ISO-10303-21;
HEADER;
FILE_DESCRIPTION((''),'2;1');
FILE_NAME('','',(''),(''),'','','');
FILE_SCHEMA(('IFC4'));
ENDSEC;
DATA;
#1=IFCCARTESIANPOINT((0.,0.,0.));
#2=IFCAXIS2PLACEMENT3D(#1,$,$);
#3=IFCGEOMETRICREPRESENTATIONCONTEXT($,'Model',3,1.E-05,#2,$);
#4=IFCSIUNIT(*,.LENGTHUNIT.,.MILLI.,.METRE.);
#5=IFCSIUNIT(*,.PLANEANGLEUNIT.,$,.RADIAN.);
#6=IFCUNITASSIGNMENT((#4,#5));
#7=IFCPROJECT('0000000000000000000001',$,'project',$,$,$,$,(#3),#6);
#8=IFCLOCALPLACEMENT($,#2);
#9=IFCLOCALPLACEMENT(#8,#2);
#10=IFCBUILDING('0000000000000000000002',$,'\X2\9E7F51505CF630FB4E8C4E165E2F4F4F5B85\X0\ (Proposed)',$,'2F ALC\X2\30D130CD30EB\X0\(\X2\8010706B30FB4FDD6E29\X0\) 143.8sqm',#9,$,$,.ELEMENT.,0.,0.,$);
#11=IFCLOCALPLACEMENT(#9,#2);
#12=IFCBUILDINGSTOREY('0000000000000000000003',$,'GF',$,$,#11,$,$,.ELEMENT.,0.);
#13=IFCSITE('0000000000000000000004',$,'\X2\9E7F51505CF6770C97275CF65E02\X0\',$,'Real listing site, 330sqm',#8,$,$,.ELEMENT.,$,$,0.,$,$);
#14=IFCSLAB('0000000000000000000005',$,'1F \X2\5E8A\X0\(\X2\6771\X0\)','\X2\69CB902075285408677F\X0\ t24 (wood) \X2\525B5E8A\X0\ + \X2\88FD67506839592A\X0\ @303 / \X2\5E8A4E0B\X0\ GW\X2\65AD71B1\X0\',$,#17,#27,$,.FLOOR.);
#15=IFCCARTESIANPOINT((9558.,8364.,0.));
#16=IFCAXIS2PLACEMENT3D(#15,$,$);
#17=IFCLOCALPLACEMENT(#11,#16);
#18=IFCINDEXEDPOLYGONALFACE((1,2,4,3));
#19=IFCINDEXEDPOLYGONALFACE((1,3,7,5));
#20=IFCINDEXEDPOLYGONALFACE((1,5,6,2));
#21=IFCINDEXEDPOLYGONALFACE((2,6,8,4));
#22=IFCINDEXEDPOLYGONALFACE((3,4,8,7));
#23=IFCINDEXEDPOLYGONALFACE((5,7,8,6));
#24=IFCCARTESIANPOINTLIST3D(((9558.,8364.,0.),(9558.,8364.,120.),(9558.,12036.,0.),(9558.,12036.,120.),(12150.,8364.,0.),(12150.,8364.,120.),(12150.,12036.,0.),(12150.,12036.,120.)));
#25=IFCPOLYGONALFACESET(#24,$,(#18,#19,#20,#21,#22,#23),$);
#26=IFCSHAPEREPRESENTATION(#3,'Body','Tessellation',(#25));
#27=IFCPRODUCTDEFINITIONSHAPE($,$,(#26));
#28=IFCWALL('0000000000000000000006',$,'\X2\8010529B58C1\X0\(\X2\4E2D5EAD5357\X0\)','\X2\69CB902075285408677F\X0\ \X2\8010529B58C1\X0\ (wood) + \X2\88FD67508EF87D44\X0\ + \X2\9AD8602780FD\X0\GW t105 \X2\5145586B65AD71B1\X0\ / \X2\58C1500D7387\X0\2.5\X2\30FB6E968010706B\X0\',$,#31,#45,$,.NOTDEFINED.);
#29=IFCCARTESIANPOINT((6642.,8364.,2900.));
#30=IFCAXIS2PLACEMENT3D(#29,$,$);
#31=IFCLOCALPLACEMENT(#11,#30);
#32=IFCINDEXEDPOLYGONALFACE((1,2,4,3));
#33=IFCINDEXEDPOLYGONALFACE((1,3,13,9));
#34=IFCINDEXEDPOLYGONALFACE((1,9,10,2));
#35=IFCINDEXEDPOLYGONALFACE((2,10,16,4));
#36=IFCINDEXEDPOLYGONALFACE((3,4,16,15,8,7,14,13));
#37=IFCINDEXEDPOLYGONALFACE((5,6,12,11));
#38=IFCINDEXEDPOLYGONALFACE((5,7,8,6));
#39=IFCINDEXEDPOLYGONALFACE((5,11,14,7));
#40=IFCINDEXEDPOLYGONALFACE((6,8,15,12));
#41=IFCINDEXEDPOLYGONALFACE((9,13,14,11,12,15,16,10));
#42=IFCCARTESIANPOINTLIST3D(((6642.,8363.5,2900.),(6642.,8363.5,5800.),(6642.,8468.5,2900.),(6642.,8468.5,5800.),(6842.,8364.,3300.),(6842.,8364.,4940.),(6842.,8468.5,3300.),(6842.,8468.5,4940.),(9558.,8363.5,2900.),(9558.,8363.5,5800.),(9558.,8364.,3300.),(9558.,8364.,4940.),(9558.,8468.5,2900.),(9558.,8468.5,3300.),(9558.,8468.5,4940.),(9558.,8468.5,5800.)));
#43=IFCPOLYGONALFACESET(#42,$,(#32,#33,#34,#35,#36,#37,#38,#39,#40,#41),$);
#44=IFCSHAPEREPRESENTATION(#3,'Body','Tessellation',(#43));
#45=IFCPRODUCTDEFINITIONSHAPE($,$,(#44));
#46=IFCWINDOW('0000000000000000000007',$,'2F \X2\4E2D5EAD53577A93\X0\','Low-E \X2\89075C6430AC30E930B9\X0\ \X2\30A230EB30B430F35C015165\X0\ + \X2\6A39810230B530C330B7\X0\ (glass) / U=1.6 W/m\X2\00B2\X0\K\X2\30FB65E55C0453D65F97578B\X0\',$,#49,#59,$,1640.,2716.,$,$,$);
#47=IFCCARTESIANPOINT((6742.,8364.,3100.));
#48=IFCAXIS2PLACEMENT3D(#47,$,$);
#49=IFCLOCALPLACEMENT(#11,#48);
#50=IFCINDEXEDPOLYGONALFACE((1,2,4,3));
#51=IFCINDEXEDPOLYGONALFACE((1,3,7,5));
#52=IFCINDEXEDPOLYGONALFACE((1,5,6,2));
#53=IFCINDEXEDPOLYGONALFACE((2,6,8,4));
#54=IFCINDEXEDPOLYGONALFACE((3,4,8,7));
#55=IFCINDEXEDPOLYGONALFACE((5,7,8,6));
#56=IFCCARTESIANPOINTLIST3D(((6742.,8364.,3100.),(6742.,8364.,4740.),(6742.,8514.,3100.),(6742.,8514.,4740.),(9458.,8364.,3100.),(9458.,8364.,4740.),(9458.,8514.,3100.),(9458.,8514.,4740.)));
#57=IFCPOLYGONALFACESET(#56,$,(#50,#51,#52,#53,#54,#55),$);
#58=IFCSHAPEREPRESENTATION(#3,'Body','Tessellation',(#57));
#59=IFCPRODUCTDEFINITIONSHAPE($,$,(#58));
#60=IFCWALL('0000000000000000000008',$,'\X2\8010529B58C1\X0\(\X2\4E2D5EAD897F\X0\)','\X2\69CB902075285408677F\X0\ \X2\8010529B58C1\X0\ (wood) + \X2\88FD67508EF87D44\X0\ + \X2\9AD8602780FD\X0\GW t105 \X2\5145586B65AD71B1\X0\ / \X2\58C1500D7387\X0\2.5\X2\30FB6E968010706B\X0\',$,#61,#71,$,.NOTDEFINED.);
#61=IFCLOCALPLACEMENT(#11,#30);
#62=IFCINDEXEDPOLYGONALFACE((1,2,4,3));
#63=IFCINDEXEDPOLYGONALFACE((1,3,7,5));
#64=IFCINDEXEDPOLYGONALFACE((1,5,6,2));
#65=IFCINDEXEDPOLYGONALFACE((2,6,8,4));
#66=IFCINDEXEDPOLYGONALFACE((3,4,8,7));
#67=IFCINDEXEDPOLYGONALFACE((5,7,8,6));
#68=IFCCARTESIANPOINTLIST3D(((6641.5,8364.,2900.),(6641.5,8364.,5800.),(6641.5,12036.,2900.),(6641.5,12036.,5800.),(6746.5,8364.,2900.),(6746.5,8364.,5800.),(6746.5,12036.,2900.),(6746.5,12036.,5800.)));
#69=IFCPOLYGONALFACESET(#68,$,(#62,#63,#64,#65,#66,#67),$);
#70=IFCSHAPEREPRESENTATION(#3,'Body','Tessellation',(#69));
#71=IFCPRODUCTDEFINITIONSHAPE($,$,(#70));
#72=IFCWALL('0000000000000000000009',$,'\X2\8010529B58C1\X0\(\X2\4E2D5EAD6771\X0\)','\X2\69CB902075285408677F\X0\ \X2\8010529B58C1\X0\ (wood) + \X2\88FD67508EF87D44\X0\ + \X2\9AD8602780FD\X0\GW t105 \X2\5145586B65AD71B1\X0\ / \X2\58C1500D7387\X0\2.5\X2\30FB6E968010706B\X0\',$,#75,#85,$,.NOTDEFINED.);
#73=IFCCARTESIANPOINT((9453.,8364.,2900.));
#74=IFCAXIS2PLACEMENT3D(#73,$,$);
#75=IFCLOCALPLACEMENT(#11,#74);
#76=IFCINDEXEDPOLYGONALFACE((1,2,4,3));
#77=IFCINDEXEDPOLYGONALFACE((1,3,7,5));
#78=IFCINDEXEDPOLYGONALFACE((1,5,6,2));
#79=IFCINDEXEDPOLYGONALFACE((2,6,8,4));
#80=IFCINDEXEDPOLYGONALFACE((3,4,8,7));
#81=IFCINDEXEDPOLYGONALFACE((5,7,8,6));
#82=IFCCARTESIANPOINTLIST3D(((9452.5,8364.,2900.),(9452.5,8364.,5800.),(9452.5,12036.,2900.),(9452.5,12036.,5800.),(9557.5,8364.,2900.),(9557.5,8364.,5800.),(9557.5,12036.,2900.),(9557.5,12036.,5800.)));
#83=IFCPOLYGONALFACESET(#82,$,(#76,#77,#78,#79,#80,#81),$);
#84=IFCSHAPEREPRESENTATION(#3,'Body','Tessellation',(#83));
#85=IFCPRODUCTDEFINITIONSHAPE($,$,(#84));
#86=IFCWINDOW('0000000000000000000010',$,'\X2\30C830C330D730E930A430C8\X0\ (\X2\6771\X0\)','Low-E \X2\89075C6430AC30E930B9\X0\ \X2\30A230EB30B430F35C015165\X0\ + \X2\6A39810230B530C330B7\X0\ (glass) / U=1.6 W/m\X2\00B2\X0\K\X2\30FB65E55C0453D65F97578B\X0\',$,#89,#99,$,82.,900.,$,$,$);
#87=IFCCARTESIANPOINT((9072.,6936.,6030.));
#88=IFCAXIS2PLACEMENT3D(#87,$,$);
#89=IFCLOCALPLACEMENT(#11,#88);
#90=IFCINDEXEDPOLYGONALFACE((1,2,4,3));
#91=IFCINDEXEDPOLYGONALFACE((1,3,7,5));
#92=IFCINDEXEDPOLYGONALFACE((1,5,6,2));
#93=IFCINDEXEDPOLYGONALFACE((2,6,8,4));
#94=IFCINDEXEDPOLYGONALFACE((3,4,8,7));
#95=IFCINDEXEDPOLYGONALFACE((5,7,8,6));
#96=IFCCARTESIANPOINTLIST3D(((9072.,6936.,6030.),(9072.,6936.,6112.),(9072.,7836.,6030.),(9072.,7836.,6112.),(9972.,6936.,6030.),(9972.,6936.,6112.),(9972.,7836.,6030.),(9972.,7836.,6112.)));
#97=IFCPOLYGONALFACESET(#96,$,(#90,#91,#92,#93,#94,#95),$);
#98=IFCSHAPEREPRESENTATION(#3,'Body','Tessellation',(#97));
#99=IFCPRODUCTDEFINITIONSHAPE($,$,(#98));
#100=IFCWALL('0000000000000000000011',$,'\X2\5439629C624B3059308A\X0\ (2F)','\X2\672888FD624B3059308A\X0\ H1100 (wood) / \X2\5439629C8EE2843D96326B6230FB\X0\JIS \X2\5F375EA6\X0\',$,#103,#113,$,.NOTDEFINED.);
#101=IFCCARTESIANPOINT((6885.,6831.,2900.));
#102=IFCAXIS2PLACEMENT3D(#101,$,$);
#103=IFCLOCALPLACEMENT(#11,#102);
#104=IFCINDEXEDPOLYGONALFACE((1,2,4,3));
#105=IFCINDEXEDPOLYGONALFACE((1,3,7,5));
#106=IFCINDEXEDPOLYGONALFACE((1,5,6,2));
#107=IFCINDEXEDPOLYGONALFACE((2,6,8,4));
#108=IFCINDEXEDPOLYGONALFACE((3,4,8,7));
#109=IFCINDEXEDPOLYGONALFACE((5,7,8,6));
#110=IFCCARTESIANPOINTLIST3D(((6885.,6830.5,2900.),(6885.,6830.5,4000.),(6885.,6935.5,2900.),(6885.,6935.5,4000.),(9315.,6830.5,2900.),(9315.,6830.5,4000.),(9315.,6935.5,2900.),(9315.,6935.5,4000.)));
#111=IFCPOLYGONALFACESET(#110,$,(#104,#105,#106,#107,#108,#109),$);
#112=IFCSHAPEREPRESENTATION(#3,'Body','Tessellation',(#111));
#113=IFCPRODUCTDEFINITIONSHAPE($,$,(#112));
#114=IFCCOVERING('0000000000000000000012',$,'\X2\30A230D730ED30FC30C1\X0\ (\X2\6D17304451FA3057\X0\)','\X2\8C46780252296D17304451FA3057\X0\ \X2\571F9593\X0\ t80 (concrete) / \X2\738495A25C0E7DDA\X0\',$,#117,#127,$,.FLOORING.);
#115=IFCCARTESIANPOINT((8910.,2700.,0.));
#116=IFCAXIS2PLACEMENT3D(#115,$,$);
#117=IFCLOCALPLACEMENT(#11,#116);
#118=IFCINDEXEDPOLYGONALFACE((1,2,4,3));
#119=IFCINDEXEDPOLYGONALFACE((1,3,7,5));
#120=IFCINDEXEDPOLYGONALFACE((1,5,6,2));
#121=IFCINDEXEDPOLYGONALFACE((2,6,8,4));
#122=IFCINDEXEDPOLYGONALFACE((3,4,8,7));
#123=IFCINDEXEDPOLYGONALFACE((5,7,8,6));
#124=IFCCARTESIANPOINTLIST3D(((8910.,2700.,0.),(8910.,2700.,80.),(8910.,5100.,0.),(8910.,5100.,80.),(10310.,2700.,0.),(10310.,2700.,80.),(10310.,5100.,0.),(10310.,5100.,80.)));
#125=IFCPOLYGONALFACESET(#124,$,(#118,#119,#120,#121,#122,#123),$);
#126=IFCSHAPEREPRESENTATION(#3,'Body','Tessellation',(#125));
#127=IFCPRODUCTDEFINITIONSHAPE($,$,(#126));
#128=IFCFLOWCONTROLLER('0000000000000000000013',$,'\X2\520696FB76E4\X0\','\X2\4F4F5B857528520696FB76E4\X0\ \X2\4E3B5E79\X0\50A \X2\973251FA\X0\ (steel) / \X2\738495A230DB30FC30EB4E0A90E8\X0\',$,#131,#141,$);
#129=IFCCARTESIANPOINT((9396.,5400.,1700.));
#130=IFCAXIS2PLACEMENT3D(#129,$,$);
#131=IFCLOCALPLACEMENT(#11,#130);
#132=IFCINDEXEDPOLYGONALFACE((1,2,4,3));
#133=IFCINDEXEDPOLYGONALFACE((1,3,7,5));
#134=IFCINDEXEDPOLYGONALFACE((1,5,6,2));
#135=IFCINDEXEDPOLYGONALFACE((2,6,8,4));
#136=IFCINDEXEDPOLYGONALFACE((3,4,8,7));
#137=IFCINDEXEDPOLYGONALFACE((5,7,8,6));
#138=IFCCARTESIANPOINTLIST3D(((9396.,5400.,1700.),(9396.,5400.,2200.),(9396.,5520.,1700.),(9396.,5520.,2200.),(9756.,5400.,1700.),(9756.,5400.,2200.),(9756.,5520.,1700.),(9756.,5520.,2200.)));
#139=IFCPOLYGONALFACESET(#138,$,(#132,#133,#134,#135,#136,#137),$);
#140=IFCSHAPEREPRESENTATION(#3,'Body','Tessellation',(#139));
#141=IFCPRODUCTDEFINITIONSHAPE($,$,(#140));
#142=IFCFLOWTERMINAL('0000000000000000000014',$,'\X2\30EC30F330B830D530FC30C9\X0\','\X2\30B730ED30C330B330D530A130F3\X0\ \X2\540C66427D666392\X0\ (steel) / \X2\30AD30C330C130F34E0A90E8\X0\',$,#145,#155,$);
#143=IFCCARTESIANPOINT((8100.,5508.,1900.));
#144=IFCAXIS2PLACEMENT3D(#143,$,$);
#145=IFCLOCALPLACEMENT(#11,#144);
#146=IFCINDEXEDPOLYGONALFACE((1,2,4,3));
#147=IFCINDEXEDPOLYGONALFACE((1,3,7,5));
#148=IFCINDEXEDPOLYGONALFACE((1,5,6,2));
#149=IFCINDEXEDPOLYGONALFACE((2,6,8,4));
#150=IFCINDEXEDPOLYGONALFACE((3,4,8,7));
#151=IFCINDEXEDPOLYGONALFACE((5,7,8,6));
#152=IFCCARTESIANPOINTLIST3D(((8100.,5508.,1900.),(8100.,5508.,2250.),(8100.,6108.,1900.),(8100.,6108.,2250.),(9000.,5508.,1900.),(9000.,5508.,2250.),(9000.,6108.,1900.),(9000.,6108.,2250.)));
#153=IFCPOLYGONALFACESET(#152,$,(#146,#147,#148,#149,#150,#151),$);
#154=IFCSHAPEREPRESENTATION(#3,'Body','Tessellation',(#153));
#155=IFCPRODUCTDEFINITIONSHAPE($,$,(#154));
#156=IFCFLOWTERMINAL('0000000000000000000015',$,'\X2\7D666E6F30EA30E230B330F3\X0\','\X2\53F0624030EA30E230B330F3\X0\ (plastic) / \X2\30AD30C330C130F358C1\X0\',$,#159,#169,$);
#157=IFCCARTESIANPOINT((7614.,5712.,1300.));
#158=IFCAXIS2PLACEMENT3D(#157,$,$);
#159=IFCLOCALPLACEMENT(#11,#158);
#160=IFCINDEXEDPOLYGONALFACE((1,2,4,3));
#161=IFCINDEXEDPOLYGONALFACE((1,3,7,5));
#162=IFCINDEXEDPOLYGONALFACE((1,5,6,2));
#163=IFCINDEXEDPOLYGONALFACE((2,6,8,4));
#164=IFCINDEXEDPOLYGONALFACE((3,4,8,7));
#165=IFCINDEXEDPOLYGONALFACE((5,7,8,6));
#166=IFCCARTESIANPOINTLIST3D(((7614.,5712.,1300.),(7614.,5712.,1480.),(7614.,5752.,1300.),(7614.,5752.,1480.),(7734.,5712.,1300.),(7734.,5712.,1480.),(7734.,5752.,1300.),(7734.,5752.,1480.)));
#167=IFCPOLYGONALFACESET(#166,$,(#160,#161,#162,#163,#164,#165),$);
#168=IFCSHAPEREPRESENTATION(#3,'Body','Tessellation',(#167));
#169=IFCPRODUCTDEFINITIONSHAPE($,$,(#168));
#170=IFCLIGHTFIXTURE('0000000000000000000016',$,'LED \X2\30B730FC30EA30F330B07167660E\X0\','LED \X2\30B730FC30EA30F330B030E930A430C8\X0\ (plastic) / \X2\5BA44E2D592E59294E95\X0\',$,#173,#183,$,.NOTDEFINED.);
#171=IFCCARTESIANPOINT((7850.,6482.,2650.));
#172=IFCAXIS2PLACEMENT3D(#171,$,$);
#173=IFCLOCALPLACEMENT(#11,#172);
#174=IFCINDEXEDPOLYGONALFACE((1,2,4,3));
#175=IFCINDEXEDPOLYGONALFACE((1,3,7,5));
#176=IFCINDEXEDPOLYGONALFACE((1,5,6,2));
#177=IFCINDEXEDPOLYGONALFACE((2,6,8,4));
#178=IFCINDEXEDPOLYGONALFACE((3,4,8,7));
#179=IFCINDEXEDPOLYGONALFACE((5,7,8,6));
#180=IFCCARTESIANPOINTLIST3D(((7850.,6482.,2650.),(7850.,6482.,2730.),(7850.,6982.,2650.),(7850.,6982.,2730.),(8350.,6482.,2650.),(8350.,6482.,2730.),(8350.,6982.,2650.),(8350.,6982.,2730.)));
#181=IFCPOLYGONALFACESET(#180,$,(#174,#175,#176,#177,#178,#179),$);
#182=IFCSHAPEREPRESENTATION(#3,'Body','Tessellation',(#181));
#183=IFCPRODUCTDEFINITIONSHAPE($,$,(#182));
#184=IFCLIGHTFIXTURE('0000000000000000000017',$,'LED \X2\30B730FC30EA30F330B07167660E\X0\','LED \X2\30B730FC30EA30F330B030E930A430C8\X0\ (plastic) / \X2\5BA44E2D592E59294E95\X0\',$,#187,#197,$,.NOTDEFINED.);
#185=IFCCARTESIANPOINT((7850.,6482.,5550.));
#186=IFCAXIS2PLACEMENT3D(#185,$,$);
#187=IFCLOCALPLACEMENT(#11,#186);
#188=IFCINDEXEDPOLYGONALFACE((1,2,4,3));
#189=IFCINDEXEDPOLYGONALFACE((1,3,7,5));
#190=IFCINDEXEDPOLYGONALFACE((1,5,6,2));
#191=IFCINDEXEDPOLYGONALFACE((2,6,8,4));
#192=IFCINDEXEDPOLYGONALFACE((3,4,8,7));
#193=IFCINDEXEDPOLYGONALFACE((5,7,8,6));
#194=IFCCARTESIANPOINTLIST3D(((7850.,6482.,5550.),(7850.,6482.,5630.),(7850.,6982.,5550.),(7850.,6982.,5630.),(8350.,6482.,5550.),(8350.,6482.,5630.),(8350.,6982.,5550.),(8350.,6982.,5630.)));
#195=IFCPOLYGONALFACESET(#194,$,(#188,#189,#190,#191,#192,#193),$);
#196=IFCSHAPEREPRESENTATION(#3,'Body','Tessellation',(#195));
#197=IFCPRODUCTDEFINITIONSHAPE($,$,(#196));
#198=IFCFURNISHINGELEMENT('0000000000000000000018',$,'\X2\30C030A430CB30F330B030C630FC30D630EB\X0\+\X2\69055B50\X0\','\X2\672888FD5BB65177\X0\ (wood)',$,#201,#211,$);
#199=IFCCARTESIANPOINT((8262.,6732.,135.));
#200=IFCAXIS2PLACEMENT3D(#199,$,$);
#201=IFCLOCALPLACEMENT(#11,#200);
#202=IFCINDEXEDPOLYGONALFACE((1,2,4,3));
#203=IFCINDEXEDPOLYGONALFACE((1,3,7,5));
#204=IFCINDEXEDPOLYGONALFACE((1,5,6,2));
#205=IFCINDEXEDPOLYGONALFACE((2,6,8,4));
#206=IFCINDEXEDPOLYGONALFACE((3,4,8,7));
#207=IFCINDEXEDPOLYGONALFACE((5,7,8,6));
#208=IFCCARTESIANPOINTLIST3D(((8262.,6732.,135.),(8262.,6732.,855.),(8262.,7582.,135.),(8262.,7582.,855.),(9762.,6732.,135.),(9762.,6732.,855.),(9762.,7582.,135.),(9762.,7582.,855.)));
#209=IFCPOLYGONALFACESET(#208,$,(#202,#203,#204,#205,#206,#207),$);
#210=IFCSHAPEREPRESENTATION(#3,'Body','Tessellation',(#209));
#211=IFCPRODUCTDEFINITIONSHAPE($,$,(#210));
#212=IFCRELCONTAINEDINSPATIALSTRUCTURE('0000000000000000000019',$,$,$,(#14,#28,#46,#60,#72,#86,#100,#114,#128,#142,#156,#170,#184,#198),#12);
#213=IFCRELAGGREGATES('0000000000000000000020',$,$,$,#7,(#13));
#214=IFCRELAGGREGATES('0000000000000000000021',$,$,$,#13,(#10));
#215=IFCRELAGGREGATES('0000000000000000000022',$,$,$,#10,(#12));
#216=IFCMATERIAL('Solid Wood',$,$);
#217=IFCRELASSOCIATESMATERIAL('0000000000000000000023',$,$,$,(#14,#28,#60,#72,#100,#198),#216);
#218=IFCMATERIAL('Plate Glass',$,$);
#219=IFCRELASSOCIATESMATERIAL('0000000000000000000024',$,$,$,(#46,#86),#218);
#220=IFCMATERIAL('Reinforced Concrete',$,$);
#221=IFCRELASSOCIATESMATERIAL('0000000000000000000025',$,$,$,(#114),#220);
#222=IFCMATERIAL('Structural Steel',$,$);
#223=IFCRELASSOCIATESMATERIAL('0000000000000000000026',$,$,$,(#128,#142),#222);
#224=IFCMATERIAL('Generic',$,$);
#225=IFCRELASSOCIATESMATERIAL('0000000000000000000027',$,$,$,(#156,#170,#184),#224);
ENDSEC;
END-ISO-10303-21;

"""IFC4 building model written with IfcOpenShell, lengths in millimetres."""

from ifc_helpers import new_model, si_unit, frame, frame_2d, origin, place, context, project, spatial, rectangle, extrude, material, element, fill, save


model = new_model("IFC4")

# Units and contexts
model_context = context("Model", 3, precision=1e-05, world=origin())
ifc_project = project(units=[si_unit("LENGTHUNIT", "METRE", prefix="MILLI"), si_unit("PLANEANGLEUNIT", "RADIAN")], contexts=[model_context])

# Site, building, storey
site_placement = place(None, origin())
site = spatial("IfcSite", under=ifc_project, at=site_placement, Name="鹿児島県霧島市", ObjectType="Real listing site, 330sqm", CompositionType="ELEMENT", RefElevation=0.0)
building_placement = place(site_placement, origin())
building = spatial("IfcBuilding", under=site, at=building_placement, Name="鹿児島・二世帯住宅 (Proposed)", ObjectType="2F ALCパネル(耐火・保温) 143.8sqm", CompositionType="ELEMENT", ElevationOfRefHeight=0.0, ElevationOfTerrain=0.0)
storey_placement = place(building_placement, origin())
storey = spatial("IfcBuildingStorey", under=building, at=storey_placement, Name="GF", CompositionType="ELEMENT", Elevation=0.0)

# Shared definitions
ifc_material_1 = material(Name="Solid Wood")

# Slab
slab_placement = place(storey_placement, frame((9558.0, 8364.0, 0.0)))
element("IfcSlab", 1, at=slab_placement, inside=storey, material=ifc_material_1, Name="1F 床(東)", Description="構造用合板 t24 (wood) 剛床 + 製材根太 @303 / 床下 GW断熱", PredefinedType="FLOOR", context=model_context, shape_type="SweptSolid", body=[
    extrude(rectangle(XDim=2592.0, YDim=3672.0, at=frame_2d((1296.0, 1836.0))), frame((9558.0, 8364.0, 0.0)), (0.0, 0.0, 1.0), 120.0),
])

# Wall, opening, window
wall_1_placement = place(storey_placement, frame((6642.0, 8364.0, 2900.0)))
wall_1 = element("IfcWall", 2, at=wall_1_placement, inside=storey, material=ifc_material_1, Name="耐力壁(中庭南)", Description="構造用合板 耐力壁 (wood) + 製材軸組 + 高性能GW t105 充填断熱 / 壁倍率2.5・準耐火", PredefinedType="NOTDEFINED", context=model_context, shape_type="SweptSolid", body=[
    extrude(rectangle(XDim=2916.0, YDim=105.0, at=frame_2d((1458.0, 52.0))), frame((6642.0, 8364.0, 2900.0)), (0.0, 0.0, 1.0), 2900.0),
])
opening_placement = place(storey_placement, frame((6742.0, 8364.0, 3100.0)))
opening = element("IfcOpeningElement", 3, at=opening_placement, cuts=wall_1, PredefinedType="NOTDEFINED", context=model_context, shape_type="SweptSolid", body=[
    extrude(rectangle(XDim=2716.0, YDim=150.0, at=frame_2d((1358.0, 75.0))), frame((6742.0, 8364.0, 3100.0)), (0.0, 0.0, 1.0), 1640.0),
])
ifc_material_2 = material(Name="Plate Glass")
window_1_placement = place(storey_placement, frame((6742.0, 8364.0, 3100.0)))
window_1 = element("IfcWindow", 4, at=window_1_placement, inside=storey, material=ifc_material_2, Name="2F 中庭南窓", Description="Low-E 複層ガラス アルゴン封入 + 樹脂サッシ (glass) / U=1.6 W/m²K・日射取得型", OverallHeight=1640.0, OverallWidth=2716.0, context=model_context, shape_type="SweptSolid", body=[
    extrude(rectangle(XDim=2716.0, YDim=150.0, at=frame_2d((1358.0, 75.0))), frame((6742.0, 8364.0, 3100.0)), (0.0, 0.0, 1.0), 1640.0),
])
fill(opening, window_1)

# Walls
wall_2_placement = place(storey_placement, frame((6642.0, 8364.0, 2900.0)))
element("IfcWall", 5, at=wall_2_placement, inside=storey, material=ifc_material_1, Name="耐力壁(中庭西)", Description="構造用合板 耐力壁 (wood) + 製材軸組 + 高性能GW t105 充填断熱 / 壁倍率2.5・準耐火", PredefinedType="NOTDEFINED", context=model_context, shape_type="SweptSolid", body=[
    extrude(rectangle(XDim=105.0, YDim=3672.0, at=frame_2d((52.0, 1836.0))), frame((6642.0, 8364.0, 2900.0)), (0.0, 0.0, 1.0), 2900.0),
])
wall_3_placement = place(storey_placement, frame((9453.0, 8364.0, 2900.0)))
element("IfcWall", 6, at=wall_3_placement, inside=storey, material=ifc_material_1, Name="耐力壁(中庭東)", Description="構造用合板 耐力壁 (wood) + 製材軸組 + 高性能GW t105 充填断熱 / 壁倍率2.5・準耐火", PredefinedType="NOTDEFINED", context=model_context, shape_type="SweptSolid", body=[
    extrude(rectangle(XDim=105.0, YDim=3672.0, at=frame_2d((52.0, 1836.0))), frame((9453.0, 8364.0, 2900.0)), (0.0, 0.0, 1.0), 2900.0),
])

# Window
window_2_placement = place(storey_placement, frame((9072.0, 6936.0, 6030.0)))
element("IfcWindow", 7, at=window_2_placement, inside=storey, material=ifc_material_2, Name="トップライト (東)", Description="Low-E 複層ガラス アルゴン封入 + 樹脂サッシ (glass) / U=1.6 W/m²K・日射取得型", OverallHeight=82.0, OverallWidth=900.0, context=model_context, shape_type="SweptSolid", body=[
    extrude(rectangle(XDim=900.0, YDim=900.0, at=frame_2d((450.0, 450.0))), frame((9072.0, 6936.0, 6030.0)), (0.0, 0.0, 1.0), 82.0),
])

# Wall
wall_4_placement = place(storey_placement, frame((6885.0, 6831.0, 2900.0)))
element("IfcWall", 8, at=wall_4_placement, inside=storey, material=ifc_material_1, Name="吹抜手すり (2F)", Description="木製手すり H1100 (wood) / 吹抜転落防止・JIS 強度", PredefinedType="NOTDEFINED", context=model_context, shape_type="SweptSolid", body=[
    extrude(rectangle(XDim=2430.0, YDim=105.0, at=frame_2d((1215.0, 52.0))), frame((6885.0, 6831.0, 2900.0)), (0.0, 0.0, 1.0), 1100.0),
])

# Covering
ifc_material_3 = material(Name="Reinforced Concrete")
covering_placement = place(storey_placement, frame((8910.0, 2700.0, 0.0)))
element("IfcCovering", 9, at=covering_placement, inside=storey, material=ifc_material_3, Name="アプローチ (洗い出し)", Description="豆砂利洗い出し 土間 t80 (concrete) / 玄関導線", PredefinedType="FLOORING", context=model_context, shape_type="SweptSolid", body=[
    extrude(rectangle(XDim=1400.0, YDim=2400.0, at=frame_2d((700.0, 1200.0))), frame((8910.0, 2700.0, 0.0)), (0.0, 0.0, 1.0), 80.0),
])

# Flow controller
ifc_material_4 = material(Name="Structural Steel")
flow_controller_placement = place(storey_placement, frame((9396.0, 5400.0, 1700.0)))
element("IfcFlowController", 10, at=flow_controller_placement, inside=storey, material=ifc_material_4, Name="分電盤", Description="住宅用分電盤 主幹50A 露出 (steel) / 玄関ホール上部", context=model_context, shape_type="SweptSolid", body=[
    extrude(rectangle(XDim=360.0, YDim=120.0, at=frame_2d((180.0, 60.0))), frame((9396.0, 5400.0, 1700.0)), (0.0, 0.0, 1.0), 500.0),
])

# Flow terminals
flow_terminal_1_placement = place(storey_placement, frame((8100.0, 5508.0, 1900.0)))
element("IfcFlowTerminal", 11, at=flow_terminal_1_placement, inside=storey, material=ifc_material_4, Name="レンジフード", Description="シロッコファン 同時給排 (steel) / キッチン上部", context=model_context, shape_type="SweptSolid", body=[
    extrude(rectangle(XDim=900.0, YDim=600.0, at=frame_2d((450.0, 300.0))), frame((8100.0, 5508.0, 1900.0)), (0.0, 0.0, 1.0), 350.0),
])
ifc_material_5 = material(Name="Generic")
flow_terminal_2_placement = place(storey_placement, frame((7614.0, 5712.0, 1300.0)))
element("IfcFlowTerminal", 12, at=flow_terminal_2_placement, inside=storey, material=ifc_material_5, Name="給湯リモコン", Description="台所リモコン (plastic) / キッチン壁", context=model_context, shape_type="SweptSolid", body=[
    extrude(rectangle(XDim=120.0, YDim=40.0, at=frame_2d((60.0, 20.0))), frame((7614.0, 5712.0, 1300.0)), (0.0, 0.0, 1.0), 180.0),
])

# Light fixtures
light_fixture_1_placement = place(storey_placement, frame((7850.0, 6482.0, 2650.0)))
element("IfcLightFixture", 13, at=light_fixture_1_placement, inside=storey, material=ifc_material_5, Name="LED シーリング照明", Description="LED シーリングライト (plastic) / 室中央天井", PredefinedType="NOTDEFINED", context=model_context, shape_type="SweptSolid", body=[
    extrude(rectangle(XDim=500.0, YDim=500.0, at=frame_2d((250.0, 250.0))), frame((7850.0, 6482.0, 2650.0)), (0.0, 0.0, 1.0), 80.0),
])
light_fixture_2_placement = place(storey_placement, frame((7850.0, 6482.0, 5550.0)))
element("IfcLightFixture", 14, at=light_fixture_2_placement, inside=storey, material=ifc_material_5, Name="LED シーリング照明", Description="LED シーリングライト (plastic) / 室中央天井", PredefinedType="NOTDEFINED", context=model_context, shape_type="SweptSolid", body=[
    extrude(rectangle(XDim=500.0, YDim=500.0, at=frame_2d((250.0, 250.0))), frame((7850.0, 6482.0, 5550.0)), (0.0, 0.0, 1.0), 80.0),
])

# Furnishing element
furnishing_1_placement = place(storey_placement, frame((8262.0, 6732.0, 135.0)))
element("IfcFurnishingElement", 15, at=furnishing_1_placement, inside=storey, material=ifc_material_1, Name="ダイニングテーブル+椅子", Description="木製家具 (wood)", context=model_context, shape_type="SweptSolid", body=[
    extrude(rectangle(XDim=1500.0, YDim=850.0, at=frame_2d((750.0, 425.0))), frame((8262.0, 6732.0, 135.0)), (0.0, 0.0, 1.0), 720.0),
])

save(model, "model.ifc")
